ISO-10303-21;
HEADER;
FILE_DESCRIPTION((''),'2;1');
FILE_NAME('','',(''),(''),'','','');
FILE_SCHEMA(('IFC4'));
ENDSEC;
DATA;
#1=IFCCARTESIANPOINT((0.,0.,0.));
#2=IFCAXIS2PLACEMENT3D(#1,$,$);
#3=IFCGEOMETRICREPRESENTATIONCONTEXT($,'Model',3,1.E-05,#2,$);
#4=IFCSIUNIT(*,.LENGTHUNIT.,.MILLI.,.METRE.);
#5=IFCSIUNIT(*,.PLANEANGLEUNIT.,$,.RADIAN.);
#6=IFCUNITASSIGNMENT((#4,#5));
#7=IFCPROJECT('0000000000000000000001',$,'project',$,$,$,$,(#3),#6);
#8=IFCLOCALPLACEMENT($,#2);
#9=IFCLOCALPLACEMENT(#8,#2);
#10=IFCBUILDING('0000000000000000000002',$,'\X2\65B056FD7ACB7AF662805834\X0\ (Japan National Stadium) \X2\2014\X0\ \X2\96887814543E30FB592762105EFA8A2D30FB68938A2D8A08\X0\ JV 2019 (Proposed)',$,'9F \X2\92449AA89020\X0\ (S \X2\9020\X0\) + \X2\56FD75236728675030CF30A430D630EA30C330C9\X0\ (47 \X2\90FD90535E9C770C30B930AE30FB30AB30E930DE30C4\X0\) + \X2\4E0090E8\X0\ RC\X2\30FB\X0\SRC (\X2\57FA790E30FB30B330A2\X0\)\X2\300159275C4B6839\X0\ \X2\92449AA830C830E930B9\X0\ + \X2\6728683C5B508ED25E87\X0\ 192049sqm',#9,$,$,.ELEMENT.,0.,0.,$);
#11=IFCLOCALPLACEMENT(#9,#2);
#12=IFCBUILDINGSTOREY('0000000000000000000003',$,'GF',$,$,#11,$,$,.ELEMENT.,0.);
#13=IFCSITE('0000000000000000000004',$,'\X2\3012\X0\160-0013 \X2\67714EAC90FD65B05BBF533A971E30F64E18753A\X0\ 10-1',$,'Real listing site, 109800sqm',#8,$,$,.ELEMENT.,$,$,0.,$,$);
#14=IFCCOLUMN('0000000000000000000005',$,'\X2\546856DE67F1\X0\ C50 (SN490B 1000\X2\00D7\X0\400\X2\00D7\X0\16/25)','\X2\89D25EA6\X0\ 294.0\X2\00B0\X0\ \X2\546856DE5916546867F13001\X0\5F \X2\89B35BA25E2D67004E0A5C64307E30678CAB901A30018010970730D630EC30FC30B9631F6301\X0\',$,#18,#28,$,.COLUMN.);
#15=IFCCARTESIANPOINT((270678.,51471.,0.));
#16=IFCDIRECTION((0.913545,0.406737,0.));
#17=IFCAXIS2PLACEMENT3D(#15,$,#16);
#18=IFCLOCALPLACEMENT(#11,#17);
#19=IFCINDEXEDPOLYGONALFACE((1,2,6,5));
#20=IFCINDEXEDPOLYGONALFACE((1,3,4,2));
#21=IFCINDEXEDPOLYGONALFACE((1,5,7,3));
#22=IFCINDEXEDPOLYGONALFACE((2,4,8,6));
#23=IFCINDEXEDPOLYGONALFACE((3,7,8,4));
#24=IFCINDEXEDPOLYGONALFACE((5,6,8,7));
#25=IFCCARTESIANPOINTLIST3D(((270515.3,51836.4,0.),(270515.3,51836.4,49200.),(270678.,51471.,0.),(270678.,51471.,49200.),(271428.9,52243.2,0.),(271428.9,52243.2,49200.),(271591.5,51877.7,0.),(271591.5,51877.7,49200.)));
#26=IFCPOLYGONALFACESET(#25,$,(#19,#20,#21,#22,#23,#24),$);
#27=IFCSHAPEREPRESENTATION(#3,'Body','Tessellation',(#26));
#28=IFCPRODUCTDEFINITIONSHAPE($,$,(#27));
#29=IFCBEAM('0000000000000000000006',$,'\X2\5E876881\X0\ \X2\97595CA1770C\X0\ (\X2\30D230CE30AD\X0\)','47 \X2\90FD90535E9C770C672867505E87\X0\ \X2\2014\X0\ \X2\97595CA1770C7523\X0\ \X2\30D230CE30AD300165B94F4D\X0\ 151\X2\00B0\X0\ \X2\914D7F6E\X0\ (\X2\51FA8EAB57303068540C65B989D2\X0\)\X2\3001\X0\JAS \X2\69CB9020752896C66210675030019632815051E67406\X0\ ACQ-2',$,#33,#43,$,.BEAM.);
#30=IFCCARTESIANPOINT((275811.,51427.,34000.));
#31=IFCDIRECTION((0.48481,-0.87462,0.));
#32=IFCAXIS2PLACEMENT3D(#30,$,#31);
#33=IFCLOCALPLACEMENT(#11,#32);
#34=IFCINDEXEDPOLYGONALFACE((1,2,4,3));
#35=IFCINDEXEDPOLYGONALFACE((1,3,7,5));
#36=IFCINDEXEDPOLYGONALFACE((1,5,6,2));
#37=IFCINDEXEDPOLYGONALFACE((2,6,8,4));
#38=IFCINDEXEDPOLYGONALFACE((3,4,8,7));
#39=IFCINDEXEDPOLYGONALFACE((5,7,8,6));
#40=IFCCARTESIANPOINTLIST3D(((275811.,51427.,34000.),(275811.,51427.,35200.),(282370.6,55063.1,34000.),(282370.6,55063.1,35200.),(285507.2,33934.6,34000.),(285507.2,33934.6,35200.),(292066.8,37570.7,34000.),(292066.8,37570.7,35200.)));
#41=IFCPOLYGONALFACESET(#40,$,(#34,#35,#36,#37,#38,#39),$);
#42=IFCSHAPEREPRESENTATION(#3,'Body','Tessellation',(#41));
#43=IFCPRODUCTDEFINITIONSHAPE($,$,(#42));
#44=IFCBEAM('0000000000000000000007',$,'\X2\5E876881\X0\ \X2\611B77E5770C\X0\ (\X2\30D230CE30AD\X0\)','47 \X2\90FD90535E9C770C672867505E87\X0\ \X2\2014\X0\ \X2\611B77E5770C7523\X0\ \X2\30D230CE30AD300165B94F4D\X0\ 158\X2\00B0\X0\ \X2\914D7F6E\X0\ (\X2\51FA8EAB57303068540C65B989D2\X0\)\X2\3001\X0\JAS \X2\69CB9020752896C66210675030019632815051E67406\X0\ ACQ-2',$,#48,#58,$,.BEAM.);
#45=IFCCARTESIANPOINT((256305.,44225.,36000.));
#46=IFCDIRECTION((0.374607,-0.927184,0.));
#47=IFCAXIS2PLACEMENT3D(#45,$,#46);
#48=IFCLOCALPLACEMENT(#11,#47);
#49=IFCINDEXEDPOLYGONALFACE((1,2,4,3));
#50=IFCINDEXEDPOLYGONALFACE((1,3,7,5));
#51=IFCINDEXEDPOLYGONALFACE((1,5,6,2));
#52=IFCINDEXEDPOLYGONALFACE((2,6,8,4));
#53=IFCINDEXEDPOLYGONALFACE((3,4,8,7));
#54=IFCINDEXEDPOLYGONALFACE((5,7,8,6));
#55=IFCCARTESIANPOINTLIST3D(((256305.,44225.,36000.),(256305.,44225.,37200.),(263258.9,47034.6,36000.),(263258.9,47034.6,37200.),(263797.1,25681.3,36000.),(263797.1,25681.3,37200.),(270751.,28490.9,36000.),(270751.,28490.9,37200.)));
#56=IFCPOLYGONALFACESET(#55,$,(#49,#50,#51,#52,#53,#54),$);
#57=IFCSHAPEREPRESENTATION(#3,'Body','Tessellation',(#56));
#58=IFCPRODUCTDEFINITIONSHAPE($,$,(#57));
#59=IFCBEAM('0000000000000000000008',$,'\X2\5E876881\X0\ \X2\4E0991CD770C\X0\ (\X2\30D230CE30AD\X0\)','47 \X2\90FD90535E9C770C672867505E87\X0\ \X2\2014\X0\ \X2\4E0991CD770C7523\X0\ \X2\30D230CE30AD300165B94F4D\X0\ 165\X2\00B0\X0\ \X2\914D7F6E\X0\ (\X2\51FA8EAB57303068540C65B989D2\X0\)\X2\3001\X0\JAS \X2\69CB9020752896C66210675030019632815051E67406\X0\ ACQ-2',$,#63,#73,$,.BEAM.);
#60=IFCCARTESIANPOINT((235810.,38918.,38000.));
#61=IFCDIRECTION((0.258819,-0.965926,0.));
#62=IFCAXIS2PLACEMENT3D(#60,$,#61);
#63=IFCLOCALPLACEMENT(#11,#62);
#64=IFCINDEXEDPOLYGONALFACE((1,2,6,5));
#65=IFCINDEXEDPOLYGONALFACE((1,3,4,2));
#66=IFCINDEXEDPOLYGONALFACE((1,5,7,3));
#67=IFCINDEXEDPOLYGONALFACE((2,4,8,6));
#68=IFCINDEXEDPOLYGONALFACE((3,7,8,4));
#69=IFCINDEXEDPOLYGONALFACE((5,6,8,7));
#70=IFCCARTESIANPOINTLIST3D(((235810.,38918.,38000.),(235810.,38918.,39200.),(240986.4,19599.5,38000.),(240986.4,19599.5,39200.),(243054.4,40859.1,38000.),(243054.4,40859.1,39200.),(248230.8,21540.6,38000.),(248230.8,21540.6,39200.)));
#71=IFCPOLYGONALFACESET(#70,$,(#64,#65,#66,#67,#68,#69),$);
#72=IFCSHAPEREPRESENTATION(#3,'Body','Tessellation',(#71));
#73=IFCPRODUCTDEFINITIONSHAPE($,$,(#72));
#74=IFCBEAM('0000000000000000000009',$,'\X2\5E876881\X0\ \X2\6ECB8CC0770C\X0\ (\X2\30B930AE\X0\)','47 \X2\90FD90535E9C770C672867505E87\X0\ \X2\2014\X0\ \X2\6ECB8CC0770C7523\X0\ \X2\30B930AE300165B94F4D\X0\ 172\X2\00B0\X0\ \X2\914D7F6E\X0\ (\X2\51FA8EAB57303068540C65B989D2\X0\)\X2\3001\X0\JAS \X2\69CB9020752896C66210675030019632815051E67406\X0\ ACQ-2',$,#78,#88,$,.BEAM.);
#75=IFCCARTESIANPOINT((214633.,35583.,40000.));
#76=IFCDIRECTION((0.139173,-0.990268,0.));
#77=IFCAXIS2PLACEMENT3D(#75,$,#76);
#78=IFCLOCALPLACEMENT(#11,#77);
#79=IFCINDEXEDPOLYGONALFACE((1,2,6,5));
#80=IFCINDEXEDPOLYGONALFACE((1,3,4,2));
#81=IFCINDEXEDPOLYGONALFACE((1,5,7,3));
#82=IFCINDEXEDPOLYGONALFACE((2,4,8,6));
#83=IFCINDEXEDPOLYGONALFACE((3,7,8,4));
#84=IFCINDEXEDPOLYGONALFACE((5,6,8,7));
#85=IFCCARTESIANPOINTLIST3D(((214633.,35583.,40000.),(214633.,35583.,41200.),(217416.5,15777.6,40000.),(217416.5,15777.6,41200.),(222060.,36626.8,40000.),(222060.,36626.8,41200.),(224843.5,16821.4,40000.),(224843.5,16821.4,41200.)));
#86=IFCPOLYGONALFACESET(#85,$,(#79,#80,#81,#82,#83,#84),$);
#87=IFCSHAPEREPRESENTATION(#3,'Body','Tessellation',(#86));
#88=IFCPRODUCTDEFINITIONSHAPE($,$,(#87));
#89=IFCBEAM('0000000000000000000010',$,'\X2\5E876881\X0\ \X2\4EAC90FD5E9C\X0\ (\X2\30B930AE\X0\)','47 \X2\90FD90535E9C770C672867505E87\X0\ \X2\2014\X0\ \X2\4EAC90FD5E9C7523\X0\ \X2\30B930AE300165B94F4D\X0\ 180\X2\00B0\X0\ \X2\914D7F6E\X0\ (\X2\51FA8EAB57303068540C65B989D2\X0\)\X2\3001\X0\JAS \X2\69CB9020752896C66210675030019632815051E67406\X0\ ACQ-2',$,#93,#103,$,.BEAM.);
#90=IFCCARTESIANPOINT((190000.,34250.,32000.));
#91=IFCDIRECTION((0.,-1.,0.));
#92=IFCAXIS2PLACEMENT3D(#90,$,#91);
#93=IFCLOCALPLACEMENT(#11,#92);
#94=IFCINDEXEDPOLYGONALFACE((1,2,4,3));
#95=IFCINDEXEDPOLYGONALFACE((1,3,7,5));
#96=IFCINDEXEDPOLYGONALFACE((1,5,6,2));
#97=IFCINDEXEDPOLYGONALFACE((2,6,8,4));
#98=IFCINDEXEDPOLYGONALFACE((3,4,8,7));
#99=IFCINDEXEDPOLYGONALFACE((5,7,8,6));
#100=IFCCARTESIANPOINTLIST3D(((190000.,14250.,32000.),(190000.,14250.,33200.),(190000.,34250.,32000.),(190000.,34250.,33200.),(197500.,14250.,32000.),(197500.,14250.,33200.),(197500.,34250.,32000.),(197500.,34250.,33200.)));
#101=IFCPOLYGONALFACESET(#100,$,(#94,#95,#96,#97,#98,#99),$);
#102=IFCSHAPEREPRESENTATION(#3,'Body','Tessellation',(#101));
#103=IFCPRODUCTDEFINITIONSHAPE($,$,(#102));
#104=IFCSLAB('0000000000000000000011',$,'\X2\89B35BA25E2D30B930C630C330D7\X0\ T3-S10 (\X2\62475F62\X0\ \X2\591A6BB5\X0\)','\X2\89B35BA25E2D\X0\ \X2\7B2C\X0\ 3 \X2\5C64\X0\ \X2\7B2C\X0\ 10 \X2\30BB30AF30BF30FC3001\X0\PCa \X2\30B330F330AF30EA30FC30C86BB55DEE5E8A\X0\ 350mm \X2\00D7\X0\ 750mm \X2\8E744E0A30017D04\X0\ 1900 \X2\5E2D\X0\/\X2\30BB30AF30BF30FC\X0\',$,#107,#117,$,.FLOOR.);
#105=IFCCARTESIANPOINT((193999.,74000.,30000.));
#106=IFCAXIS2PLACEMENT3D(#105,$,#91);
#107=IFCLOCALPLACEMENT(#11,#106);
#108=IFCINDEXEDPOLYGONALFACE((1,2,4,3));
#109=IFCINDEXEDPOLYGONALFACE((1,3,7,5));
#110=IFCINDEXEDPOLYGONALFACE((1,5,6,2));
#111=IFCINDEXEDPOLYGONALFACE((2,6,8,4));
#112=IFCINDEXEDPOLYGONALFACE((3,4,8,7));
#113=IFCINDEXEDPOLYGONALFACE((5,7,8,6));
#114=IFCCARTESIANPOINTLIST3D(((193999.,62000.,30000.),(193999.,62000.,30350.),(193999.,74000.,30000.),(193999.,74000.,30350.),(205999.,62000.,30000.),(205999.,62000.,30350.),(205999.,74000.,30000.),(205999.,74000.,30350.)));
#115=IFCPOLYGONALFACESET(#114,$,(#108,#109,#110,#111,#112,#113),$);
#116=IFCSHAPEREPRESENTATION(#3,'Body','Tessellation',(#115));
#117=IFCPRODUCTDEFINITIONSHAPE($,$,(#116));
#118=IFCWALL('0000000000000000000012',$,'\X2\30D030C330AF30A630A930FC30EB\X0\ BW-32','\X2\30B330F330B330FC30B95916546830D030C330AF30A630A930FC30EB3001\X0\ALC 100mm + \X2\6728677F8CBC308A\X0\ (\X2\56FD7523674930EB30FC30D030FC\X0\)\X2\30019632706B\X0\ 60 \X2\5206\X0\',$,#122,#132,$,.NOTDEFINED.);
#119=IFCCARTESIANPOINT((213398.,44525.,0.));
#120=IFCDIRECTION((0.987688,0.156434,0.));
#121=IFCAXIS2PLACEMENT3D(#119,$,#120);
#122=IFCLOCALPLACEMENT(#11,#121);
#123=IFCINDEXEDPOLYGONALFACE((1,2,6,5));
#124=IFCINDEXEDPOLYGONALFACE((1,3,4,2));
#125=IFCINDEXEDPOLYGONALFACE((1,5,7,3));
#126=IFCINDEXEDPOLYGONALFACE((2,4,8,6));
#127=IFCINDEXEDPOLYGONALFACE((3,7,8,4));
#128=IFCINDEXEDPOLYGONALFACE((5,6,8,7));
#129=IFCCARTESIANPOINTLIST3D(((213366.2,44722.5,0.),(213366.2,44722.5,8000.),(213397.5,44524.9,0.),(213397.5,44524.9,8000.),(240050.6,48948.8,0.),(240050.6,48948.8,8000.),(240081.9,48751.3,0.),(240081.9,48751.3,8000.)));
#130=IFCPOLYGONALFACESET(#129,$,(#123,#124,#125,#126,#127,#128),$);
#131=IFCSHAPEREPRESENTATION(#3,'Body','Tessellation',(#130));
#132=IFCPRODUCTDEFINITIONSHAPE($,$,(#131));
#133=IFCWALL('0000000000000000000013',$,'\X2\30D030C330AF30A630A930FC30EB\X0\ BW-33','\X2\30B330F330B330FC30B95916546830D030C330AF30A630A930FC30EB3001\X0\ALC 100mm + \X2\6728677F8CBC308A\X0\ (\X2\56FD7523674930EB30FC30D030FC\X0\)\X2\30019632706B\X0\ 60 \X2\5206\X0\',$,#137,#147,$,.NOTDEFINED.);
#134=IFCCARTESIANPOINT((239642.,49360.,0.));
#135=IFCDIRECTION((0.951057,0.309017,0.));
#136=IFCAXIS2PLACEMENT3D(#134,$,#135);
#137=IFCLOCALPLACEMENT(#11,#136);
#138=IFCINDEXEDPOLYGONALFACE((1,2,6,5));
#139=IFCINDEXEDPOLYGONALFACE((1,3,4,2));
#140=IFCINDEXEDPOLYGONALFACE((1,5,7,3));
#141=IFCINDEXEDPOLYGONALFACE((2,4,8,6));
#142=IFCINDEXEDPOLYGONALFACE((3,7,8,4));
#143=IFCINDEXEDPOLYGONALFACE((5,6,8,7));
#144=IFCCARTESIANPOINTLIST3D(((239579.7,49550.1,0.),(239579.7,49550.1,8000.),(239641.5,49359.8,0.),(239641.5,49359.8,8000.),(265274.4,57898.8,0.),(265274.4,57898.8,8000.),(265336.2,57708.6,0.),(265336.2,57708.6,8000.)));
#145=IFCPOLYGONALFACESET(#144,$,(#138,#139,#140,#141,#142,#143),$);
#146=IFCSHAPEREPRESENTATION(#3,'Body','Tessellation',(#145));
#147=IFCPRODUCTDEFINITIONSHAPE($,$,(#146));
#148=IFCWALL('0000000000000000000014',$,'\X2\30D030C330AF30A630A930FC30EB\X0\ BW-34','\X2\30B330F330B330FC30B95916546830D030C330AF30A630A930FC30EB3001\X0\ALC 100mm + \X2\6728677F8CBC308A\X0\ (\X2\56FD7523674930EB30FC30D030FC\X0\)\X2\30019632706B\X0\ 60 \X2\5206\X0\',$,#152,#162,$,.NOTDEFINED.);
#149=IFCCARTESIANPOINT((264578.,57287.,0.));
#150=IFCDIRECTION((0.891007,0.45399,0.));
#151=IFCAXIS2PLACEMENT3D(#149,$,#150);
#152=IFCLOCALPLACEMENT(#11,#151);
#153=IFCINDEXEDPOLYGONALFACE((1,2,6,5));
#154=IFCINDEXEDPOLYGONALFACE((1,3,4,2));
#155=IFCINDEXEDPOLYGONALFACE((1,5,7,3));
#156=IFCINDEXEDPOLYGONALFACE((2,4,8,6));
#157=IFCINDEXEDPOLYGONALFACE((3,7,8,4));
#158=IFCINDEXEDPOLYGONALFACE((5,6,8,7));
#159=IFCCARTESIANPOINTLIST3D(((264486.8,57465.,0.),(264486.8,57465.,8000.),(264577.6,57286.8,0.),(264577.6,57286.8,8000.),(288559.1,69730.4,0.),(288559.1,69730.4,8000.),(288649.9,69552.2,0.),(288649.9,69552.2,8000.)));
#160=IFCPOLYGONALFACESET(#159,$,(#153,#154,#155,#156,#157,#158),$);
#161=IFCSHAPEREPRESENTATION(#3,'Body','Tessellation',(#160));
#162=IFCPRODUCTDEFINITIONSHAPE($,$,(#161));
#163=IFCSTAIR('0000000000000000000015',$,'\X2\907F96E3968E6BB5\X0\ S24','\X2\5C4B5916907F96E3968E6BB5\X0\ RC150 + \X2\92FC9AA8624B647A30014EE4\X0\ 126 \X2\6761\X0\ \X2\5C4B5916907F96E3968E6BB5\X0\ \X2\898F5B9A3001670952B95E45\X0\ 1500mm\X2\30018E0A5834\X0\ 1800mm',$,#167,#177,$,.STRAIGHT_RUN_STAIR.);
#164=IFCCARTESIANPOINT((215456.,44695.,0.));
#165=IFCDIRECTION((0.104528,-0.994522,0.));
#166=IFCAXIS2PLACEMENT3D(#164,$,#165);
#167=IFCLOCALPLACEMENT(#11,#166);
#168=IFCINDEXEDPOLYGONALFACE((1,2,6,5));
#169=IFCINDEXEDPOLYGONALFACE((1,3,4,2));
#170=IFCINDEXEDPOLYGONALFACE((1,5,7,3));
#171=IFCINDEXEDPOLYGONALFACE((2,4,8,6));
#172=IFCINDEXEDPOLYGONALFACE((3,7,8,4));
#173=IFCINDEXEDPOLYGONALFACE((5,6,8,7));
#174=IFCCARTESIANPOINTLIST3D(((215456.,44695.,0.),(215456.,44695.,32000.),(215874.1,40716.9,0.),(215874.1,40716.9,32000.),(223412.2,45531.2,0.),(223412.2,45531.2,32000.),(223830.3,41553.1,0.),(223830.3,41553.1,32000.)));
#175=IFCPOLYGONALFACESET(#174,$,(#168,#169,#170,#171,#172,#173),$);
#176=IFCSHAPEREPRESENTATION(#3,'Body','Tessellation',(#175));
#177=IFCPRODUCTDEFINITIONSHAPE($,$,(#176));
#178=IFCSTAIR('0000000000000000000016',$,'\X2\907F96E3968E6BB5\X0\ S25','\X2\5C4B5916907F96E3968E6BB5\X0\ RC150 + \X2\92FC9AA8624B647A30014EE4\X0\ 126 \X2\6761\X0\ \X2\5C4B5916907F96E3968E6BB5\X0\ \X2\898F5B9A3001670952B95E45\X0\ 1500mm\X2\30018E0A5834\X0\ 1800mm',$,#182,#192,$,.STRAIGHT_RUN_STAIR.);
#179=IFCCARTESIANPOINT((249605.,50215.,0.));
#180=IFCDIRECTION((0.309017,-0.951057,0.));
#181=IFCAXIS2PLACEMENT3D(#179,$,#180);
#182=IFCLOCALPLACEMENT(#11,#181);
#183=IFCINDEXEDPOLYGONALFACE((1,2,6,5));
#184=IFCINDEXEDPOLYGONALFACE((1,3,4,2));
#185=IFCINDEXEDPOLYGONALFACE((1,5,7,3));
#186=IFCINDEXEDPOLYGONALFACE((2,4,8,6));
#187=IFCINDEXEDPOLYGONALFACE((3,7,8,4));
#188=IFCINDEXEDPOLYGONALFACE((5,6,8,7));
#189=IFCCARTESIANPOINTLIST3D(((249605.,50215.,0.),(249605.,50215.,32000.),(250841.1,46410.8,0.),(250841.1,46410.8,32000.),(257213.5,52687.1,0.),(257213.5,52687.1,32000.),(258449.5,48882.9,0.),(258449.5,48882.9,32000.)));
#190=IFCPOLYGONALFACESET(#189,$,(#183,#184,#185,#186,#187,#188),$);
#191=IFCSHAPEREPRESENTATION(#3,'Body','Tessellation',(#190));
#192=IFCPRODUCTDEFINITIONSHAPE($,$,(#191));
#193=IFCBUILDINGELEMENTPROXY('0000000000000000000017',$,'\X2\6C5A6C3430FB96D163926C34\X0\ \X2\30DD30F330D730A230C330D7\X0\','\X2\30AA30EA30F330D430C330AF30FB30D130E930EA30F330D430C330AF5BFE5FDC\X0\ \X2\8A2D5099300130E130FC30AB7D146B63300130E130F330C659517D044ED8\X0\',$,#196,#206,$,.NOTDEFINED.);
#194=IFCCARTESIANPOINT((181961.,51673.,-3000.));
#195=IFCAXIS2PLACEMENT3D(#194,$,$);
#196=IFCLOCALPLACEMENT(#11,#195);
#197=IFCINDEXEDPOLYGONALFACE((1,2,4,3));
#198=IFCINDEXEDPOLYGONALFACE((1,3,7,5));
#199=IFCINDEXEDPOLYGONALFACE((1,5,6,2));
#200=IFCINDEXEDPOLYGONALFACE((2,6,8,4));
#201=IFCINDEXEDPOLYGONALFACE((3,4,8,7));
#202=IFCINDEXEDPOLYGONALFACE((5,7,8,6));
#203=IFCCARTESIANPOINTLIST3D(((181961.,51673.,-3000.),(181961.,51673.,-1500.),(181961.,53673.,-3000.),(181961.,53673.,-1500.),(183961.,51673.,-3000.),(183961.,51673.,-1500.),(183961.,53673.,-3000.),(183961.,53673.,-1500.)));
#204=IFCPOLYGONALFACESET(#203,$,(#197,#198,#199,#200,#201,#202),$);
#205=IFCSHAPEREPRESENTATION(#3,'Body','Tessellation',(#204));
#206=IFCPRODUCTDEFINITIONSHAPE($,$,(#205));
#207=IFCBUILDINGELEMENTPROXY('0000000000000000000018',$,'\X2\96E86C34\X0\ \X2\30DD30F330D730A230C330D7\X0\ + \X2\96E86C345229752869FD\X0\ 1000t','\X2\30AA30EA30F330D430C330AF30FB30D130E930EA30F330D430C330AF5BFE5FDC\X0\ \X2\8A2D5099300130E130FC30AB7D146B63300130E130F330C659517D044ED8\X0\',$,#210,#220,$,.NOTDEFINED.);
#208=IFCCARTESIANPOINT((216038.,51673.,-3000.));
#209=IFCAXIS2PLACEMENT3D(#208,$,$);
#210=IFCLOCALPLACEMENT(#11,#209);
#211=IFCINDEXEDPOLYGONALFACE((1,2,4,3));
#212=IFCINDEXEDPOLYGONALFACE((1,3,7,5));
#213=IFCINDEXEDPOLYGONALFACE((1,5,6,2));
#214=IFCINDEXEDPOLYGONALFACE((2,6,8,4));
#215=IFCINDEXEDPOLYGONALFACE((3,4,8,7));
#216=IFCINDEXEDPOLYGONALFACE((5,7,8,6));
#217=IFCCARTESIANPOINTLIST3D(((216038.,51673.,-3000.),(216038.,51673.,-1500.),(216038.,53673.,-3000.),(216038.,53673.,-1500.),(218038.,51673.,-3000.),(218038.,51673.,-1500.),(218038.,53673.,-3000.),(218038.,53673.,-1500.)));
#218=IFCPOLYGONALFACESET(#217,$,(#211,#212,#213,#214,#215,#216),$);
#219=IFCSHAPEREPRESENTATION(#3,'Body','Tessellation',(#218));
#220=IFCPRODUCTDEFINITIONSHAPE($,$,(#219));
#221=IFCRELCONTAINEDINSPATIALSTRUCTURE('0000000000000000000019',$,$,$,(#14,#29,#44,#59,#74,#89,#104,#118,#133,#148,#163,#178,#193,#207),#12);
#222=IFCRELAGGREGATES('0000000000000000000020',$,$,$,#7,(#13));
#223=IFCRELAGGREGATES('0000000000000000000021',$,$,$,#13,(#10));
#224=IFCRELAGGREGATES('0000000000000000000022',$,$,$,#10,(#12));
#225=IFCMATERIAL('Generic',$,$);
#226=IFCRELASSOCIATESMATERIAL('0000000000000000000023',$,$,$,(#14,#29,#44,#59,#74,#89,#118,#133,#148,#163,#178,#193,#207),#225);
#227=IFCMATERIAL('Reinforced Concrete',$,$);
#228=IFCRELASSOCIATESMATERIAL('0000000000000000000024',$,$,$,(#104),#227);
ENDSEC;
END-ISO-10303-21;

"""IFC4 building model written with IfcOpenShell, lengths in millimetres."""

from ifc_helpers import new_model, si_unit, frame, frame_2d, origin, place, context, project, spatial, rectangle, extrude, material, element, save


model = new_model("IFC4")

# Units and contexts
model_context = context("Model", 3, precision=1e-05, world=origin())
ifc_project = project(units=[si_unit("LENGTHUNIT", "METRE", prefix="MILLI"), si_unit("PLANEANGLEUNIT", "RADIAN")], contexts=[model_context])

# Site, building, storey
site_placement = place(None, origin())
site = spatial("IfcSite", under=ifc_project, at=site_placement, Name="〒160-0013 東京都新宿区霞ヶ丘町 10-1", ObjectType="Real listing site, 109800sqm", CompositionType="ELEMENT", RefElevation=0.0)
building_placement = place(site_placement, origin())
building = spatial("IfcBuilding", under=site, at=building_placement, Name="新国立競技場 (Japan National Stadium) — 隈研吾・大成建設・梓設計 JV 2019 (Proposed)", ObjectType="9F 鉄骨造 (S 造) + 国産木材ハイブリッド (47 都道府県スギ・カラマツ) + 一部 RC・SRC (基礎・コア)、大屋根 鉄骨トラス + 木格子軒庇 192049sqm", CompositionType="ELEMENT", ElevationOfRefHeight=0.0, ElevationOfTerrain=0.0)
storey_placement = place(building_placement, origin())
storey = spatial("IfcBuildingStorey", under=building, at=storey_placement, Name="GF", CompositionType="ELEMENT", Elevation=0.0)

# Shared definitions
ifc_material_1 = material(Name="Reinforced Concrete")

# Column
ifc_material_2 = material(Name="Generic")
column_1_placement = place(storey_placement, frame((270678.0, 51471.0, 0.0), x_axis=(0.913545, 0.406737, 0.0)))
element("IfcColumn", 1, at=column_1_placement, inside=storey, material=ifc_material_2, Name="周回柱 C50 (SN490B 1000×400×16/25)", Description="角度 294.0° 周回外周柱、5F 観客席最上層まで貫通、耐震ブレース挟持", PredefinedType="COLUMN", context=model_context, shape_type="SweptSolid", body=[
    extrude(rectangle(XDim=1000.0, YDim=400.0, at=frame_2d((500.0, 200.0))), frame((270678.0, 51471.0, 0.0), x_axis=(0.913545, 0.406737, 0.0)), (0.0, 0.0, 1.0), 49200.0),
])

# Beams
beam_1_placement = place(storey_placement, frame((275811.0, 51427.0, 34000.0), x_axis=(0.48481, -0.87462, 0.0)))
element("IfcBeam", 2, at=beam_1_placement, inside=storey, material=ifc_material_2, Name="庇梁 静岡県 (ヒノキ)", Description="47 都道府県木材庇 — 静岡県産 ヒノキ、方位 151° 配置 (出身地と同方角)、JAS 構造用集成材、防腐処理 ACQ-2", PredefinedType="BEAM", context=model_context, shape_type="SweptSolid", body=[
    extrude(rectangle(XDim=20000.0, YDim=7500.0, at=frame_2d((10000.0, 3750.0))), frame((275811.0, 51427.0, 34000.0), x_axis=(0.48481, -0.87462, 0.0)), (0.0, 0.0, 1.0), 1200.0),
])
beam_2_placement = place(storey_placement, frame((256305.0, 44225.0, 36000.0), x_axis=(0.374607, -0.927184, 0.0)))
element("IfcBeam", 3, at=beam_2_placement, inside=storey, material=ifc_material_2, Name="庇梁 愛知県 (ヒノキ)", Description="47 都道府県木材庇 — 愛知県産 ヒノキ、方位 158° 配置 (出身地と同方角)、JAS 構造用集成材、防腐処理 ACQ-2", PredefinedType="BEAM", context=model_context, shape_type="SweptSolid", body=[
    extrude(rectangle(XDim=20000.0, YDim=7500.0, at=frame_2d((10000.0, 3750.0))), frame((256305.0, 44225.0, 36000.0), x_axis=(0.374607, -0.927184, 0.0)), (0.0, 0.0, 1.0), 1200.0),
])
beam_3_placement = place(storey_placement, frame((235810.0, 38918.0, 38000.0), x_axis=(0.258819, -0.965926, 0.0)))
element("IfcBeam", 4, at=beam_3_placement, inside=storey, material=ifc_material_2, Name="庇梁 三重県 (ヒノキ)", Description="47 都道府県木材庇 — 三重県産 ヒノキ、方位 165° 配置 (出身地と同方角)、JAS 構造用集成材、防腐処理 ACQ-2", PredefinedType="BEAM", context=model_context, shape_type="SweptSolid", body=[
    extrude(rectangle(XDim=20000.0, YDim=7500.0, at=frame_2d((10000.0, 3750.0))), frame((235810.0, 38918.0, 38000.0), x_axis=(0.258819, -0.965926, 0.0)), (0.0, 0.0, 1.0), 1200.0),
])
beam_4_placement = place(storey_placement, frame((214633.0, 35583.0, 40000.0), x_axis=(0.139173, -0.990268, 0.0)))
element("IfcBeam", 5, at=beam_4_placement, inside=storey, material=ifc_material_2, Name="庇梁 滋賀県 (スギ)", Description="47 都道府県木材庇 — 滋賀県産 スギ、方位 172° 配置 (出身地と同方角)、JAS 構造用集成材、防腐処理 ACQ-2", PredefinedType="BEAM", context=model_context, shape_type="SweptSolid", body=[
    extrude(rectangle(XDim=20000.0, YDim=7500.0, at=frame_2d((10000.0, 3750.0))), frame((214633.0, 35583.0, 40000.0), x_axis=(0.139173, -0.990268, 0.0)), (0.0, 0.0, 1.0), 1200.0),
])
beam_5_placement = place(storey_placement, frame((190000.0, 34250.0, 32000.0), x_axis=(0.0, -1.0, 0.0)))
element("IfcBeam", 6, at=beam_5_placement, inside=storey, material=ifc_material_2, Name="庇梁 京都府 (スギ)", Description="47 都道府県木材庇 — 京都府産 スギ、方位 180° 配置 (出身地と同方角)、JAS 構造用集成材、防腐処理 ACQ-2", PredefinedType="BEAM", context=model_context, shape_type="SweptSolid", body=[
    extrude(rectangle(XDim=20000.0, YDim=7500.0, at=frame_2d((10000.0, 3750.0))), frame((190000.0, 34250.0, 32000.0), x_axis=(0.0, -1.0, 0.0)), (0.0, 0.0, 1.0), 1200.0),
])

# Slab
slab_placement = place(storey_placement, frame((193999.0, 74000.0, 30000.0), x_axis=(0.0, -1.0, 0.0)))
element("IfcSlab", 7, at=slab_placement, inside=storey, material=ifc_material_1, Name="観客席ステップ T3-S10 (扇形 多段)", Description="観客席 第 3 層 第 10 セクター、PCa コンクリート段差床 350mm × 750mm 蹴上、約 1900 席/セクター", PredefinedType="FLOOR", context=model_context, shape_type="SweptSolid", body=[
    extrude(rectangle(XDim=12000.0, YDim=12000.0, at=frame_2d((6000.0, 6000.0))), frame((193999.0, 74000.0, 30000.0), x_axis=(0.0, -1.0, 0.0)), (0.0, 0.0, 1.0), 350.0),
])

# Walls
wall_1_placement = place(storey_placement, frame((213398.0, 44525.0, 0.0), x_axis=(0.987688, 0.156434, 0.0)))
element("IfcWall", 8, at=wall_1_placement, inside=storey, material=ifc_material_2, Name="バックウォール BW-32", Description="コンコース外周バックウォール、ALC 100mm + 木板貼り (国産杉ルーバー)、防火 60 分", PredefinedType="NOTDEFINED", context=model_context, shape_type="SweptSolid", body=[
    extrude(rectangle(XDim=27017.0, YDim=200.0, at=frame_2d((13508.0, 100.0))), frame((213398.0, 44525.0, 0.0), x_axis=(0.987688, 0.156434, 0.0)), (0.0, 0.0, 1.0), 8000.0),
])
wall_2_placement = place(storey_placement, frame((239642.0, 49360.0, 0.0), x_axis=(0.951057, 0.309017, 0.0)))
element("IfcWall", 9, at=wall_2_placement, inside=storey, material=ifc_material_2, Name="バックウォール BW-33", Description="コンコース外周バックウォール、ALC 100mm + 木板貼り (国産杉ルーバー)、防火 60 分", PredefinedType="NOTDEFINED", context=model_context, shape_type="SweptSolid", body=[
    extrude(rectangle(XDim=27017.0, YDim=200.0, at=frame_2d((13508.0, 100.0))), frame((239642.0, 49360.0, 0.0), x_axis=(0.951057, 0.309017, 0.0)), (0.0, 0.0, 1.0), 8000.0),
])
wall_3_placement = place(storey_placement, frame((264578.0, 57287.0, 0.0), x_axis=(0.891007, 0.45399, 0.0)))
element("IfcWall", 10, at=wall_3_placement, inside=storey, material=ifc_material_2, Name="バックウォール BW-34", Description="コンコース外周バックウォール、ALC 100mm + 木板貼り (国産杉ルーバー)、防火 60 分", PredefinedType="NOTDEFINED", context=model_context, shape_type="SweptSolid", body=[
    extrude(rectangle(XDim=27017.0, YDim=200.0, at=frame_2d((13508.0, 100.0))), frame((264578.0, 57287.0, 0.0), x_axis=(0.891007, 0.45399, 0.0)), (0.0, 0.0, 1.0), 8000.0),
])

# Stairs
stair_1_placement = place(storey_placement, frame((215456.0, 44695.0, 0.0), x_axis=(0.104528, -0.994522, 0.0)))
element("IfcStair", 11, at=stair_1_placement, inside=storey, material=ifc_material_2, Name="避難階段 S24", Description="屋外避難階段 RC150 + 鋼骨手摺、令 126 条 屋外避難階段 規定、有効幅 1500mm、踊場 1800mm", PredefinedType="STRAIGHT_RUN_STAIR", context=model_context, shape_type="SweptSolid", body=[
    extrude(rectangle(XDim=4000.0, YDim=8000.0, at=frame_2d((2000.0, 4000.0))), frame((215456.0, 44695.0, 0.0), x_axis=(0.104528, -0.994522, 0.0)), (0.0, 0.0, 1.0), 32000.0),
])
stair_2_placement = place(storey_placement, frame((249605.0, 50215.0, 0.0), x_axis=(0.309017, -0.951057, 0.0)))
element("IfcStair", 12, at=stair_2_placement, inside=storey, material=ifc_material_2, Name="避難階段 S25", Description="屋外避難階段 RC150 + 鋼骨手摺、令 126 条 屋外避難階段 規定、有効幅 1500mm、踊場 1800mm", PredefinedType="STRAIGHT_RUN_STAIR", context=model_context, shape_type="SweptSolid", body=[
    extrude(rectangle(XDim=4000.0, YDim=8000.0, at=frame_2d((2000.0, 4000.0))), frame((249605.0, 50215.0, 0.0), x_axis=(0.309017, -0.951057, 0.0)), (0.0, 0.0, 1.0), 32000.0),
])

# Building element proxies
proxy_1_placement = place(storey_placement, frame((181961.0, 51673.0, -3000.0)))
element("IfcBuildingElementProxy", 13, at=proxy_1_placement, inside=storey, material=ifc_material_2, Name="汚水・雑排水 ポンプアップ", Description="オリンピック・パラリンピック対応 設備、メーカ純正、メンテ契約付", PredefinedType="NOTDEFINED", context=model_context, shape_type="SweptSolid", body=[
    extrude(rectangle(XDim=2000.0, YDim=2000.0, at=frame_2d((1000.0, 1000.0))), frame((181961.0, 51673.0, -3000.0)), (0.0, 0.0, 1.0), 1500.0),
])
proxy_2_placement = place(storey_placement, frame((216038.0, 51673.0, -3000.0)))
element("IfcBuildingElementProxy", 14, at=proxy_2_placement, inside=storey, material=ifc_material_2, Name="雨水 ポンプアップ + 雨水利用槽 1000t", Description="オリンピック・パラリンピック対応 設備、メーカ純正、メンテ契約付", PredefinedType="NOTDEFINED", context=model_context, shape_type="SweptSolid", body=[
    extrude(rectangle(XDim=2000.0, YDim=2000.0, at=frame_2d((1000.0, 1000.0))), frame((216038.0, 51673.0, -3000.0)), (0.0, 0.0, 1.0), 1500.0),
])

save(model, "model.ifc")
